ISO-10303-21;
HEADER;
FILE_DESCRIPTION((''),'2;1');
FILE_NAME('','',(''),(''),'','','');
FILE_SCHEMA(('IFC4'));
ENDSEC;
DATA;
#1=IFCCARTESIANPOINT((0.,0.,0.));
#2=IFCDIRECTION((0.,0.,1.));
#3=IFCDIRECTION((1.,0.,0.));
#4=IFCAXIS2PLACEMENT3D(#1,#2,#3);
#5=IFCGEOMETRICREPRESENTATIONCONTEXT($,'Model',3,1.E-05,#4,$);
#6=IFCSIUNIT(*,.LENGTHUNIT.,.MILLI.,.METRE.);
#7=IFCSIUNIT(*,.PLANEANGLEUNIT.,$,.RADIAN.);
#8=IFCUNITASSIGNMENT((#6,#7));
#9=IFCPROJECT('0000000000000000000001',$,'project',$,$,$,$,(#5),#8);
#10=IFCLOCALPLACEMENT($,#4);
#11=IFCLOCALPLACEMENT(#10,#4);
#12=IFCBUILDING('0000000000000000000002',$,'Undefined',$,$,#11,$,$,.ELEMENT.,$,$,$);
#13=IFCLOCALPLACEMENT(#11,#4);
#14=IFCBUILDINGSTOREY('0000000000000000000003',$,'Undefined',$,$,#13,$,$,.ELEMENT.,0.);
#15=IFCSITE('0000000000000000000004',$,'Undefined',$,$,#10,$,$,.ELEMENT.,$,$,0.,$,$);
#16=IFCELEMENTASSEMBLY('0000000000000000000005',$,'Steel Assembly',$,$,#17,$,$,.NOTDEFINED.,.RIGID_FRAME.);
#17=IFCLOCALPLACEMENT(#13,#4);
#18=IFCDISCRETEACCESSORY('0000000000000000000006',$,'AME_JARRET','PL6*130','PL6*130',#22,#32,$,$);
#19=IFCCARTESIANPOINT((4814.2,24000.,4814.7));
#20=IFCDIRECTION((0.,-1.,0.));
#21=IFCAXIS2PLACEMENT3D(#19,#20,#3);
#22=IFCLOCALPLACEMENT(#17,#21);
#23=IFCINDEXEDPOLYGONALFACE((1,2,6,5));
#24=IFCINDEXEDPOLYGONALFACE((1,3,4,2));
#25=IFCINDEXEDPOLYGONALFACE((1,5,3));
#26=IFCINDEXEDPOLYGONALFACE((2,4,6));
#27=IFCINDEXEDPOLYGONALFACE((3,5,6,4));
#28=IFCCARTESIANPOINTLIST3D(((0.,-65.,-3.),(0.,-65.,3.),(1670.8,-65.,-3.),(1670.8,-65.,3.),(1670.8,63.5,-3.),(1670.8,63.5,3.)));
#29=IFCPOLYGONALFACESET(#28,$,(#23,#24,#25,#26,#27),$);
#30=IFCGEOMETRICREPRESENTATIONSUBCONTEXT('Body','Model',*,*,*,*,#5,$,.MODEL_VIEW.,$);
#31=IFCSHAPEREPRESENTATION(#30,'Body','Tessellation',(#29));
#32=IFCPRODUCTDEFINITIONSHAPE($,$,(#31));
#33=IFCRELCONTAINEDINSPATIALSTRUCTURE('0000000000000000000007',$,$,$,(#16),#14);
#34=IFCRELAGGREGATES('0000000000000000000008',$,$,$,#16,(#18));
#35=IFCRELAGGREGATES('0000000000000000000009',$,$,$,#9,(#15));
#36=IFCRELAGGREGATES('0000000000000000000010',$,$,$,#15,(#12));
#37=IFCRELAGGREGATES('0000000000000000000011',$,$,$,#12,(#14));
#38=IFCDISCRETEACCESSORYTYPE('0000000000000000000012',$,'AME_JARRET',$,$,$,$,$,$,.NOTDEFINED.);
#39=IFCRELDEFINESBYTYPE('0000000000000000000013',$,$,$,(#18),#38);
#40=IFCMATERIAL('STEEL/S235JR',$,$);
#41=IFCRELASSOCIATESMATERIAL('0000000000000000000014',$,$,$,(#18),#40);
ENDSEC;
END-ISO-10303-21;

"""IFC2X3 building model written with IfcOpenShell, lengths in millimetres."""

from ifc_helpers import new_model, si_unit, frame, origin_with_axes, place, context, subcontext, project, spatial, polyline, outline, extrude, clip, halfspace, material, type_object, element, aggregate, save


model = new_model("IFC2X3")

# Units and contexts
model_context = context("Model", 3, precision=1e-05, world=origin_with_axes())
body_context = subcontext(model_context, "Body", "Model", "MODEL_VIEW")
ifc_project = project(units=[si_unit("LENGTHUNIT", "METRE", prefix="MILLI"), si_unit("PLANEANGLEUNIT", "RADIAN")], contexts=[model_context])

# Site, building, storey
site_placement = place(None, origin_with_axes())
site = spatial("IfcSite", under=ifc_project, at=site_placement, Name="Undefined", CompositionType="ELEMENT", RefElevation=0.0)
building_placement = place(site_placement, origin_with_axes())
building = spatial("IfcBuilding", under=site, at=building_placement, Name="Undefined", CompositionType="ELEMENT")
storey_placement = place(building_placement, origin_with_axes())
storey = spatial("IfcBuildingStorey", under=building, at=storey_placement, Name="Undefined", CompositionType="ELEMENT", Elevation=0.0)

# Element assembly
ifc_material_1 = material(Name="STEEL/S235JR")
assembly_1_placement = place(storey_placement, origin_with_axes())
assembly_1 = element("IfcElementAssembly", 1, at=assembly_1_placement, inside=storey, Name="Steel Assembly", AssemblyPlace="NOTDEFINED", PredefinedType="RIGID_FRAME")

# Discrete accessory
discrete_accessory_type_1 = type_object("IfcDiscreteAccessoryType", Name="AME_JARRET")
discrete_accessory_1_placement = place(assembly_1_placement, frame((4814.2, 24000.0, 4814.7), z_axis=(0.0, -1.0, 0.0), x_axis=(1.0, 0.0, 0.0)))
discrete_accessory_1 = element("IfcDiscreteAccessory", 2, at=discrete_accessory_1_placement, type_object=discrete_accessory_type_1, material=ifc_material_1, Name="AME_JARRET", Description="PL6*130", ObjectType="PL6*130", context=body_context, shape_type="Clipping", body=[
    clip(clip(extrude(outline(polyline([(1670.8, -65.0), (0.0, -65.0), (1670.8, 63.5), (1670.8, -65.0)])), frame((0.0, 0.0, -3.0), z_axis=(0.0, 0.0, 1.0), x_axis=(1.0, 0.0, 0.0)), (0.0, 0.0, 1.0), 6.0), halfspace(frame((1670.8, 63.5, -3.0), z_axis=(-0.076696, 0.997054, 0.0), x_axis=(0.0, 0.0, 1.0)), False)), halfspace(frame((1670.8, -65.0, 3.0), z_axis=(1.0, 0.0, 0.0), x_axis=(0.0, 1.0, 0.0)), False)),
])

aggregate(assembly_1, [discrete_accessory_1])

save(model, "model.ifc")
